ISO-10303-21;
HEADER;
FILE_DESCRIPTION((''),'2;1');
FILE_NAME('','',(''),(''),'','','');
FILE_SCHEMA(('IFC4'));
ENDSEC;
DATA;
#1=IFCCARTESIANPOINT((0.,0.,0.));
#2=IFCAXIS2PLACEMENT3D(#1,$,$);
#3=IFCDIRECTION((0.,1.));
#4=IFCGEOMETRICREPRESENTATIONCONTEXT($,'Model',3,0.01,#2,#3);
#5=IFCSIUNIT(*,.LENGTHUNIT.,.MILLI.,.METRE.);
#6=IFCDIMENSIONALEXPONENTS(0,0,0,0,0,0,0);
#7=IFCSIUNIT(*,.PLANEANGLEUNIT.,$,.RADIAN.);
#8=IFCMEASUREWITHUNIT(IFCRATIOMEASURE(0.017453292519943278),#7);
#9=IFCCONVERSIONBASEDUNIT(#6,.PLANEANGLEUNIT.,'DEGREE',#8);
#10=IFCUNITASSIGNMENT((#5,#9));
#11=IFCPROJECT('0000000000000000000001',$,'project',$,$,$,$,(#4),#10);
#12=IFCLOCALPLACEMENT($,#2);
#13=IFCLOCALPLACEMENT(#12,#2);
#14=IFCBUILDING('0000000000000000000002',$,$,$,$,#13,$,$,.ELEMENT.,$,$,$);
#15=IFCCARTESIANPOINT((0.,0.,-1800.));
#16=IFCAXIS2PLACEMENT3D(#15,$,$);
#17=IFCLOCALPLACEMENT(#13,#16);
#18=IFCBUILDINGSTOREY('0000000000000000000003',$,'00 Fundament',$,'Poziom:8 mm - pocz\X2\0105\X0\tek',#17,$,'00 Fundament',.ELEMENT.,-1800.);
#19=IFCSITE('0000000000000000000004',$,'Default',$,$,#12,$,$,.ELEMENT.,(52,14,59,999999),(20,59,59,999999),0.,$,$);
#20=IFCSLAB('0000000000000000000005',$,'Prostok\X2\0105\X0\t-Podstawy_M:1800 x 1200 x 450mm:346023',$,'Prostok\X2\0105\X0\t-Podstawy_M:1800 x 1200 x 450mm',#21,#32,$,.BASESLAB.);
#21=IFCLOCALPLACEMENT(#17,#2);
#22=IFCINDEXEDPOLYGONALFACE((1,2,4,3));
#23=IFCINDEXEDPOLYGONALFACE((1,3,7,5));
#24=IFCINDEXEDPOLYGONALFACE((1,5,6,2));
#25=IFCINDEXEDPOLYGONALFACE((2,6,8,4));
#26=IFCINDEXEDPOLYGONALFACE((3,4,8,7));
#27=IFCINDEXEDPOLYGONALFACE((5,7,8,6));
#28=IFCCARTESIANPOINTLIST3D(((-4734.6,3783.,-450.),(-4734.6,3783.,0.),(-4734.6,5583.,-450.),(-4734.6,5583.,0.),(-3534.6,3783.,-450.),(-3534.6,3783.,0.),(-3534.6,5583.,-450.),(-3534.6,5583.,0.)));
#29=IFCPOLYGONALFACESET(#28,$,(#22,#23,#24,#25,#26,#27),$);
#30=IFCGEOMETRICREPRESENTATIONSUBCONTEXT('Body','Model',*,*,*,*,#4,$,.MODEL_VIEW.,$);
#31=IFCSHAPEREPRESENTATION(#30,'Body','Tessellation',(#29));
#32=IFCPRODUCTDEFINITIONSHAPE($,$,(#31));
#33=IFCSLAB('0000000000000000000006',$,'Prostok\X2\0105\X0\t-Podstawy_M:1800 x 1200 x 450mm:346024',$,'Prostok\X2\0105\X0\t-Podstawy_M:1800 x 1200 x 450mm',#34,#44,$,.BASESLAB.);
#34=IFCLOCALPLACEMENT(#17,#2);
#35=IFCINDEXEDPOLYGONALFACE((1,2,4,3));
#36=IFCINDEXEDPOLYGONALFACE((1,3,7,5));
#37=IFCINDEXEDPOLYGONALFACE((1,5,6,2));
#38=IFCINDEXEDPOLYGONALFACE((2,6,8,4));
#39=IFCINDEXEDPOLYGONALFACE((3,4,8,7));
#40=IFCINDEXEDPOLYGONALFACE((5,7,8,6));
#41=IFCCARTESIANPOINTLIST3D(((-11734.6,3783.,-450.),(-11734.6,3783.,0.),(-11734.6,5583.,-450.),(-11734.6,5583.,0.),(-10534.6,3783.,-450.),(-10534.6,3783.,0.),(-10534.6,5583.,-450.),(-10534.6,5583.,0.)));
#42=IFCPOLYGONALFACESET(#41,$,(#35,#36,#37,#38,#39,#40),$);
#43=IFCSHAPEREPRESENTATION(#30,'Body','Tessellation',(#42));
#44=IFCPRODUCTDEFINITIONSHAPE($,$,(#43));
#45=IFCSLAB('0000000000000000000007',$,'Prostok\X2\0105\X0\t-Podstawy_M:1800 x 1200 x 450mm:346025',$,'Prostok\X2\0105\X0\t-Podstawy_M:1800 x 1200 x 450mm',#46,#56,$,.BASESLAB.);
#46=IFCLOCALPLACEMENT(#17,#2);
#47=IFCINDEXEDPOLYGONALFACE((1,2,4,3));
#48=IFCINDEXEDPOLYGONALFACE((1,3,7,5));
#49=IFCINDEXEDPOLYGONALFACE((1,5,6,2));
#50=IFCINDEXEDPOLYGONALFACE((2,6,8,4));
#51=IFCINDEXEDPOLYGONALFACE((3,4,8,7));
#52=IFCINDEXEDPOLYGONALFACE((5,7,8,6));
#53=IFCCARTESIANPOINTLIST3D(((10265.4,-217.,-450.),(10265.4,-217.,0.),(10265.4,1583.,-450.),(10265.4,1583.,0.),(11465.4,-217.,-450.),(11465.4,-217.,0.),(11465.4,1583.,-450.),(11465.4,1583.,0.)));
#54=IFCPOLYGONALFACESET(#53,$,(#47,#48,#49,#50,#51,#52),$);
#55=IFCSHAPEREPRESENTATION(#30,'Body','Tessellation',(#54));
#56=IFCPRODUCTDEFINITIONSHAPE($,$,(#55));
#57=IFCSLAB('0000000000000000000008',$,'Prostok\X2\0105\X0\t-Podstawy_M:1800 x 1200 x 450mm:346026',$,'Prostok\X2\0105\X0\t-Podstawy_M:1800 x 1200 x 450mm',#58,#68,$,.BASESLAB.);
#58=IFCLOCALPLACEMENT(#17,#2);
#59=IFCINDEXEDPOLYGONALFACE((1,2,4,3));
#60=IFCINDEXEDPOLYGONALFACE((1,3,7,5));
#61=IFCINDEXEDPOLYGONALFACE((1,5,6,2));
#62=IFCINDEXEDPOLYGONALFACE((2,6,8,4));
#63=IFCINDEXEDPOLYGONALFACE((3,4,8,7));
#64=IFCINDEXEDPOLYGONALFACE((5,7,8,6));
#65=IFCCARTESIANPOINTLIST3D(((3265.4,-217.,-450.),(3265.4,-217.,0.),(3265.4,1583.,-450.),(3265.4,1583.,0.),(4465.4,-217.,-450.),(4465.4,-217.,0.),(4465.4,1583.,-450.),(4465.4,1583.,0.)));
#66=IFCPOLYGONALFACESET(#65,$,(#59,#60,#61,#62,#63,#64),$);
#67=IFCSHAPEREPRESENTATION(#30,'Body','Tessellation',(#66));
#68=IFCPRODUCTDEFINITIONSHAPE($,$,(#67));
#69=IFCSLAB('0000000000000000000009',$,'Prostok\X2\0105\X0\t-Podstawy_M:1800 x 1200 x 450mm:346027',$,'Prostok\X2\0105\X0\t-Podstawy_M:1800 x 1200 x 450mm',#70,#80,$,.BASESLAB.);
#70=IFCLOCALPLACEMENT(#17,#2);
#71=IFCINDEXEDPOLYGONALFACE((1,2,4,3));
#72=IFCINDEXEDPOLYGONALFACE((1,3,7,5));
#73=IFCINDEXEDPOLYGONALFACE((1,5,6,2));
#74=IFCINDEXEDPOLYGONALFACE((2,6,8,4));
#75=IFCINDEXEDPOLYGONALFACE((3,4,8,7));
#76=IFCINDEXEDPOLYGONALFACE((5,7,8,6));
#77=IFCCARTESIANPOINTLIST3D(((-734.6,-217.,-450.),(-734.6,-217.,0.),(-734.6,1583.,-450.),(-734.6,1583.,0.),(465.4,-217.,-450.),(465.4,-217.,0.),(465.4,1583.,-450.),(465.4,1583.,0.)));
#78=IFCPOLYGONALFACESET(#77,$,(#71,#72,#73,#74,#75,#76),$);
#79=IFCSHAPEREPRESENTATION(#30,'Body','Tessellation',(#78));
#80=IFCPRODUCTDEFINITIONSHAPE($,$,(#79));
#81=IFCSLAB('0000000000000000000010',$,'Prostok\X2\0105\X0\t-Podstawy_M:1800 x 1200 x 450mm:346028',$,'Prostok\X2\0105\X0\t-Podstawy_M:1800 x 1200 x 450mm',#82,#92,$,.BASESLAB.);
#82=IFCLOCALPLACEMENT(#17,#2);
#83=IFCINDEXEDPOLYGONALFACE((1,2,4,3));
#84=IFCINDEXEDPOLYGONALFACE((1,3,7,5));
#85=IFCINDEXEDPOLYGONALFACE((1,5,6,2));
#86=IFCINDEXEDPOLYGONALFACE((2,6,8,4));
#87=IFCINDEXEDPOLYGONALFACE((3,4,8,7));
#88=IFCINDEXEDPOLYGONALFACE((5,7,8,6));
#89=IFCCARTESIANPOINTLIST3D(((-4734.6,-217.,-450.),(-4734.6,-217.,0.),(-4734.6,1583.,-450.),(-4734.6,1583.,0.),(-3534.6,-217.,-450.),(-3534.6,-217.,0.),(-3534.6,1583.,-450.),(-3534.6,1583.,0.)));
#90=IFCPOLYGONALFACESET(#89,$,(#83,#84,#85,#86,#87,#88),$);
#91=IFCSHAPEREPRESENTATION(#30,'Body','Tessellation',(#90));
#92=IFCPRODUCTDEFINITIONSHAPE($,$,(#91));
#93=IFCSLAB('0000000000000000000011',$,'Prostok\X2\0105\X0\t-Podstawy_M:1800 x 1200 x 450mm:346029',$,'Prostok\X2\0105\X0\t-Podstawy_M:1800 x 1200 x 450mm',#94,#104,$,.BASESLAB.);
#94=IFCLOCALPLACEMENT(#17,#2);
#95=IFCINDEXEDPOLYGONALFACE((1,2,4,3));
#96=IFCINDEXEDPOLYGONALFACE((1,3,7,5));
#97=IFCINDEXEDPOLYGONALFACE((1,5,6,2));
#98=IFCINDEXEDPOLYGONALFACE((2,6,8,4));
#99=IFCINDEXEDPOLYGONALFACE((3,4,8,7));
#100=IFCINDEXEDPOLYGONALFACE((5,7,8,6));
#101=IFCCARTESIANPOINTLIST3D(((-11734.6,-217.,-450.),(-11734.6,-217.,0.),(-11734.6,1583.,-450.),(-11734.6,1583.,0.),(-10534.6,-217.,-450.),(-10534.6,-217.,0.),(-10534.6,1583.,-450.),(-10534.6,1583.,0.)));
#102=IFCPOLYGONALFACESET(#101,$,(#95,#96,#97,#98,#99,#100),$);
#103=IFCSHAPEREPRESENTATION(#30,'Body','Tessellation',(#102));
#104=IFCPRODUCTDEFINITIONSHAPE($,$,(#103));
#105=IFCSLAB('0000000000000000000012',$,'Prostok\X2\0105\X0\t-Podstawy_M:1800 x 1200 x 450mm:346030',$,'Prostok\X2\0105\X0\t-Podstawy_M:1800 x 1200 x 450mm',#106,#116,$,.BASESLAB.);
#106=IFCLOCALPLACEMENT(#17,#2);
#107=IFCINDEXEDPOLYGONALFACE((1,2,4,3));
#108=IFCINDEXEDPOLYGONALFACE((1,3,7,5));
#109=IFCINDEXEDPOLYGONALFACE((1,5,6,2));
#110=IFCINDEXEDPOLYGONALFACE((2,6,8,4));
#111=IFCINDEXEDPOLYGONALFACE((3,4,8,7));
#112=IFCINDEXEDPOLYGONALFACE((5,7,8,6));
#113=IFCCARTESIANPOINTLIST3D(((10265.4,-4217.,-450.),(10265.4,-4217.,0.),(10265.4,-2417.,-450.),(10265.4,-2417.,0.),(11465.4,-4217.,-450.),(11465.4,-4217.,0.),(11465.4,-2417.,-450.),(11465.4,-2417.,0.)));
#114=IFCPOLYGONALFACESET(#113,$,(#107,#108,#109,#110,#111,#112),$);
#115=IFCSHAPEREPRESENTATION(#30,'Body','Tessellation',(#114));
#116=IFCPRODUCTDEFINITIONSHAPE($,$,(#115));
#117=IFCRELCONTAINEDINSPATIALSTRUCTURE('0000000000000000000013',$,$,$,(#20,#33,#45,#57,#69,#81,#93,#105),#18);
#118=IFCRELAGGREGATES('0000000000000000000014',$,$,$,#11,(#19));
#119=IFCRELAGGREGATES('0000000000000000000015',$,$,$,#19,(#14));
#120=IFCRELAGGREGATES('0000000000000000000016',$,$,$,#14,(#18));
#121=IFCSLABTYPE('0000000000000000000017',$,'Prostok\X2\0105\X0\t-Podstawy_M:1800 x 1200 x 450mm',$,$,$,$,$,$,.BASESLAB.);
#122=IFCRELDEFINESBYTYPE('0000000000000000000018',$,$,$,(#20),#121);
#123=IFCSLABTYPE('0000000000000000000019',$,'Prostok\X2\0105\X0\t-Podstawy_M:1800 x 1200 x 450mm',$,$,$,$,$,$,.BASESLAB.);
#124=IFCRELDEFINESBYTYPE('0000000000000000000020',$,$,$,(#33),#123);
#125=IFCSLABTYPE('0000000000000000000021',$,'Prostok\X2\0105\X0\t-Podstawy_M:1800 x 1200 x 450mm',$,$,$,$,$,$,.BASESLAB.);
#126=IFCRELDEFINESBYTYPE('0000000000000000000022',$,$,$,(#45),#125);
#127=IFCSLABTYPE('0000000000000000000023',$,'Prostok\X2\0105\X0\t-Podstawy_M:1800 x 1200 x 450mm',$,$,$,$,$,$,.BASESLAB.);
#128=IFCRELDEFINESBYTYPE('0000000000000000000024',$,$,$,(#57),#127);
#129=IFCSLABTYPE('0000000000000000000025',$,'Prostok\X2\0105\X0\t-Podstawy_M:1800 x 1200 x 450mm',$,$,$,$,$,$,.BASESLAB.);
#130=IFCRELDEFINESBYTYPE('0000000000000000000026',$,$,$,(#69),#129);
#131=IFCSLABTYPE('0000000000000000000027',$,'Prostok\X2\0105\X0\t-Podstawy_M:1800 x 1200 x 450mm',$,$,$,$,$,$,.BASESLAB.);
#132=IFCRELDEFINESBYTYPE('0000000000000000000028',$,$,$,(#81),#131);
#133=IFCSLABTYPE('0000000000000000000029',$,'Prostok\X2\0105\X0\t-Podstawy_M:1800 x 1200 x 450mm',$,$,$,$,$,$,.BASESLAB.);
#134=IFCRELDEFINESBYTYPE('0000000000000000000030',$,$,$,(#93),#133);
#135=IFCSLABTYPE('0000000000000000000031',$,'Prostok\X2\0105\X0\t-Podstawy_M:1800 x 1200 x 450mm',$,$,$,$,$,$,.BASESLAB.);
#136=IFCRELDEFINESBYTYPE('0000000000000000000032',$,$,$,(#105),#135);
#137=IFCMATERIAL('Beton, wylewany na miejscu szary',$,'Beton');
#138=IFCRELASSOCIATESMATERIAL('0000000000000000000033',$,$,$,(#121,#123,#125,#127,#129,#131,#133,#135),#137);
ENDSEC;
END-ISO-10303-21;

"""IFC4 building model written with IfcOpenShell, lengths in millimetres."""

from ifc_helpers import new_model, entity, si_unit, converted_unit, direction, frame, origin, place, context, subcontext, project, spatial, indexed_curve, outline, extrude, material, type_object, element, save


model = new_model("IFC4")

# Units and contexts
model_context = context("Model", 3, precision=0.01, world=origin(), true_north=direction((0.0, 1.0)))
body_context = subcontext(model_context, "Body", "Model", "MODEL_VIEW")
ifc_project = project(units=[si_unit("LENGTHUNIT", "METRE", prefix="MILLI"), converted_unit("PLANEANGLEUNIT", "DEGREE", entity("IfcRatioMeasure", 0.017453292519943278), si_unit("PLANEANGLEUNIT", "RADIAN"), dimensions=[0, 0, 0, 0, 0, 0, 0])], contexts=[model_context])

# Site, building, storey
site_placement = place(None, origin())
site = spatial("IfcSite", under=ifc_project, at=site_placement, Name="Default", CompositionType="ELEMENT", RefLatitude=(52, 14, 59, 999999), RefLongitude=(20, 59, 59, 999999), RefElevation=0.0)
building_placement = place(site_placement, origin())
building = spatial("IfcBuilding", under=site, at=building_placement, CompositionType="ELEMENT")
storey_placement = place(building_placement, frame((0.0, 0.0, -1800.0)))
storey = spatial("IfcBuildingStorey", under=building, at=storey_placement, Name="00 Fundament", ObjectType="Poziom:8 mm - początek", LongName="00 Fundament", CompositionType="ELEMENT", Elevation=-1800.0)

# Slabs
ifc_material_1 = material(Name="Beton, wylewany na miejscu szary", Category="Beton")
slab_type_1 = type_object("IfcSlabType", Name="Prostokąt-Podstawy_M:1800 x 1200 x 450mm", PredefinedType="BASESLAB", material=ifc_material_1)
slab_1_placement = place(storey_placement, origin())
element("IfcSlab", 1, at=slab_1_placement, inside=storey, type_object=slab_type_1, Name="Prostokąt-Podstawy_M:1800 x 1200 x 450mm:346023", ObjectType="Prostokąt-Podstawy_M:1800 x 1200 x 450mm", PredefinedType="BASESLAB", context=body_context, shape_type="SweptSolid", body=[
    extrude(outline(indexed_curve([(-600.0, -900.0), (600.0, -900.0), (600.0, 900.0), (-600.0, 900.0), (-600.0, -900.0)], self_intersect=False)), frame((-4134.6, 4683.0, -450.0), z_axis=(0.0, 0.0, 1.0), x_axis=(-1.0, 0.0, 0.0)), (0.0, 0.0, 1.0), 450.0),
])
slab_type_2 = type_object("IfcSlabType", Name="Prostokąt-Podstawy_M:1800 x 1200 x 450mm", PredefinedType="BASESLAB", material=ifc_material_1)
slab_2_placement = place(storey_placement, origin())
element("IfcSlab", 2, at=slab_2_placement, inside=storey, type_object=slab_type_2, Name="Prostokąt-Podstawy_M:1800 x 1200 x 450mm:346024", ObjectType="Prostokąt-Podstawy_M:1800 x 1200 x 450mm", PredefinedType="BASESLAB", context=body_context, shape_type="SweptSolid", body=[
    extrude(outline(indexed_curve([(-600.0, -900.0), (600.0, -900.0), (600.0, 900.0), (-600.0, 900.0), (-600.0, -900.0)], self_intersect=False)), frame((-11134.6, 4683.0, -450.0), z_axis=(0.0, 0.0, 1.0), x_axis=(-1.0, 0.0, 0.0)), (0.0, 0.0, 1.0), 450.0),
])
slab_type_3 = type_object("IfcSlabType", Name="Prostokąt-Podstawy_M:1800 x 1200 x 450mm", PredefinedType="BASESLAB", material=ifc_material_1)
slab_3_placement = place(storey_placement, origin())
element("IfcSlab", 3, at=slab_3_placement, inside=storey, type_object=slab_type_3, Name="Prostokąt-Podstawy_M:1800 x 1200 x 450mm:346025", ObjectType="Prostokąt-Podstawy_M:1800 x 1200 x 450mm", PredefinedType="BASESLAB", context=body_context, shape_type="SweptSolid", body=[
    extrude(outline(indexed_curve([(-600.0, -900.0), (600.0, -900.0), (600.0, 900.0), (-600.0, 900.0), (-600.0, -900.0)], self_intersect=False)), frame((10865.4, 683.0, -450.0), z_axis=(0.0, 0.0, 1.0), x_axis=(-1.0, 0.0, 0.0)), (0.0, 0.0, 1.0), 450.0),
])
slab_type_4 = type_object("IfcSlabType", Name="Prostokąt-Podstawy_M:1800 x 1200 x 450mm", PredefinedType="BASESLAB", material=ifc_material_1)
slab_4_placement = place(storey_placement, origin())
element("IfcSlab", 4, at=slab_4_placement, inside=storey, type_object=slab_type_4, Name="Prostokąt-Podstawy_M:1800 x 1200 x 450mm:346026", ObjectType="Prostokąt-Podstawy_M:1800 x 1200 x 450mm", PredefinedType="BASESLAB", context=body_context, shape_type="SweptSolid", body=[
    extrude(outline(indexed_curve([(-600.0, -900.0), (600.0, -900.0), (600.0, 900.0), (-600.0, 900.0), (-600.0, -900.0)], self_intersect=False)), frame((3865.4, 683.0, -450.0), z_axis=(0.0, 0.0, 1.0), x_axis=(-1.0, 0.0, 0.0)), (0.0, 0.0, 1.0), 450.0),
])
slab_type_5 = type_object("IfcSlabType", Name="Prostokąt-Podstawy_M:1800 x 1200 x 450mm", PredefinedType="BASESLAB", material=ifc_material_1)
slab_5_placement = place(storey_placement, origin())
element("IfcSlab", 5, at=slab_5_placement, inside=storey, type_object=slab_type_5, Name="Prostokąt-Podstawy_M:1800 x 1200 x 450mm:346027", ObjectType="Prostokąt-Podstawy_M:1800 x 1200 x 450mm", PredefinedType="BASESLAB", context=body_context, shape_type="SweptSolid", body=[
    extrude(outline(indexed_curve([(-600.0, -900.0), (600.0, -900.0), (600.0, 900.0), (-600.0, 900.0), (-600.0, -900.0)], self_intersect=False)), frame((-134.6, 683.0, -450.0), z_axis=(0.0, 0.0, 1.0), x_axis=(-1.0, 0.0, 0.0)), (0.0, 0.0, 1.0), 450.0),
])
slab_type_6 = type_object("IfcSlabType", Name="Prostokąt-Podstawy_M:1800 x 1200 x 450mm", PredefinedType="BASESLAB", material=ifc_material_1)
slab_6_placement = place(storey_placement, origin())
element("IfcSlab", 6, at=slab_6_placement, inside=storey, type_object=slab_type_6, Name="Prostokąt-Podstawy_M:1800 x 1200 x 450mm:346028", ObjectType="Prostokąt-Podstawy_M:1800 x 1200 x 450mm", PredefinedType="BASESLAB", context=body_context, shape_type="SweptSolid", body=[
    extrude(outline(indexed_curve([(-600.0, -900.0), (600.0, -900.0), (600.0, 900.0), (-600.0, 900.0), (-600.0, -900.0)], self_intersect=False)), frame((-4134.6, 683.0, -450.0), z_axis=(0.0, 0.0, 1.0), x_axis=(-1.0, 0.0, 0.0)), (0.0, 0.0, 1.0), 450.0),
])
slab_type_7 = type_object("IfcSlabType", Name="Prostokąt-Podstawy_M:1800 x 1200 x 450mm", PredefinedType="BASESLAB", material=ifc_material_1)
slab_7_placement = place(storey_placement, origin())
element("IfcSlab", 7, at=slab_7_placement, inside=storey, type_object=slab_type_7, Name="Prostokąt-Podstawy_M:1800 x 1200 x 450mm:346029", ObjectType="Prostokąt-Podstawy_M:1800 x 1200 x 450mm", PredefinedType="BASESLAB", context=body_context, shape_type="SweptSolid", body=[
    extrude(outline(indexed_curve([(-600.0, -900.0), (600.0, -900.0), (600.0, 900.0), (-600.0, 900.0), (-600.0, -900.0)], self_intersect=False)), frame((-11134.6, 683.0, -450.0), z_axis=(0.0, 0.0, 1.0), x_axis=(-1.0, 0.0, 0.0)), (0.0, 0.0, 1.0), 450.0),
])
slab_type_8 = type_object("IfcSlabType", Name="Prostokąt-Podstawy_M:1800 x 1200 x 450mm", PredefinedType="BASESLAB", material=ifc_material_1)
slab_8_placement = place(storey_placement, origin())
element("IfcSlab", 8, at=slab_8_placement, inside=storey, type_object=slab_type_8, Name="Prostokąt-Podstawy_M:1800 x 1200 x 450mm:346030", ObjectType="Prostokąt-Podstawy_M:1800 x 1200 x 450mm", PredefinedType="BASESLAB", context=body_context, shape_type="SweptSolid", body=[
    extrude(outline(indexed_curve([(-600.0, -900.0), (600.0, -900.0), (600.0, 900.0), (-600.0, 900.0), (-600.0, -900.0)], self_intersect=False)), frame((10865.4, -3317.0, -450.0), z_axis=(0.0, 0.0, 1.0), x_axis=(-1.0, 0.0, 0.0)), (0.0, 0.0, 1.0), 450.0),
])

save(model, "model.ifc")
